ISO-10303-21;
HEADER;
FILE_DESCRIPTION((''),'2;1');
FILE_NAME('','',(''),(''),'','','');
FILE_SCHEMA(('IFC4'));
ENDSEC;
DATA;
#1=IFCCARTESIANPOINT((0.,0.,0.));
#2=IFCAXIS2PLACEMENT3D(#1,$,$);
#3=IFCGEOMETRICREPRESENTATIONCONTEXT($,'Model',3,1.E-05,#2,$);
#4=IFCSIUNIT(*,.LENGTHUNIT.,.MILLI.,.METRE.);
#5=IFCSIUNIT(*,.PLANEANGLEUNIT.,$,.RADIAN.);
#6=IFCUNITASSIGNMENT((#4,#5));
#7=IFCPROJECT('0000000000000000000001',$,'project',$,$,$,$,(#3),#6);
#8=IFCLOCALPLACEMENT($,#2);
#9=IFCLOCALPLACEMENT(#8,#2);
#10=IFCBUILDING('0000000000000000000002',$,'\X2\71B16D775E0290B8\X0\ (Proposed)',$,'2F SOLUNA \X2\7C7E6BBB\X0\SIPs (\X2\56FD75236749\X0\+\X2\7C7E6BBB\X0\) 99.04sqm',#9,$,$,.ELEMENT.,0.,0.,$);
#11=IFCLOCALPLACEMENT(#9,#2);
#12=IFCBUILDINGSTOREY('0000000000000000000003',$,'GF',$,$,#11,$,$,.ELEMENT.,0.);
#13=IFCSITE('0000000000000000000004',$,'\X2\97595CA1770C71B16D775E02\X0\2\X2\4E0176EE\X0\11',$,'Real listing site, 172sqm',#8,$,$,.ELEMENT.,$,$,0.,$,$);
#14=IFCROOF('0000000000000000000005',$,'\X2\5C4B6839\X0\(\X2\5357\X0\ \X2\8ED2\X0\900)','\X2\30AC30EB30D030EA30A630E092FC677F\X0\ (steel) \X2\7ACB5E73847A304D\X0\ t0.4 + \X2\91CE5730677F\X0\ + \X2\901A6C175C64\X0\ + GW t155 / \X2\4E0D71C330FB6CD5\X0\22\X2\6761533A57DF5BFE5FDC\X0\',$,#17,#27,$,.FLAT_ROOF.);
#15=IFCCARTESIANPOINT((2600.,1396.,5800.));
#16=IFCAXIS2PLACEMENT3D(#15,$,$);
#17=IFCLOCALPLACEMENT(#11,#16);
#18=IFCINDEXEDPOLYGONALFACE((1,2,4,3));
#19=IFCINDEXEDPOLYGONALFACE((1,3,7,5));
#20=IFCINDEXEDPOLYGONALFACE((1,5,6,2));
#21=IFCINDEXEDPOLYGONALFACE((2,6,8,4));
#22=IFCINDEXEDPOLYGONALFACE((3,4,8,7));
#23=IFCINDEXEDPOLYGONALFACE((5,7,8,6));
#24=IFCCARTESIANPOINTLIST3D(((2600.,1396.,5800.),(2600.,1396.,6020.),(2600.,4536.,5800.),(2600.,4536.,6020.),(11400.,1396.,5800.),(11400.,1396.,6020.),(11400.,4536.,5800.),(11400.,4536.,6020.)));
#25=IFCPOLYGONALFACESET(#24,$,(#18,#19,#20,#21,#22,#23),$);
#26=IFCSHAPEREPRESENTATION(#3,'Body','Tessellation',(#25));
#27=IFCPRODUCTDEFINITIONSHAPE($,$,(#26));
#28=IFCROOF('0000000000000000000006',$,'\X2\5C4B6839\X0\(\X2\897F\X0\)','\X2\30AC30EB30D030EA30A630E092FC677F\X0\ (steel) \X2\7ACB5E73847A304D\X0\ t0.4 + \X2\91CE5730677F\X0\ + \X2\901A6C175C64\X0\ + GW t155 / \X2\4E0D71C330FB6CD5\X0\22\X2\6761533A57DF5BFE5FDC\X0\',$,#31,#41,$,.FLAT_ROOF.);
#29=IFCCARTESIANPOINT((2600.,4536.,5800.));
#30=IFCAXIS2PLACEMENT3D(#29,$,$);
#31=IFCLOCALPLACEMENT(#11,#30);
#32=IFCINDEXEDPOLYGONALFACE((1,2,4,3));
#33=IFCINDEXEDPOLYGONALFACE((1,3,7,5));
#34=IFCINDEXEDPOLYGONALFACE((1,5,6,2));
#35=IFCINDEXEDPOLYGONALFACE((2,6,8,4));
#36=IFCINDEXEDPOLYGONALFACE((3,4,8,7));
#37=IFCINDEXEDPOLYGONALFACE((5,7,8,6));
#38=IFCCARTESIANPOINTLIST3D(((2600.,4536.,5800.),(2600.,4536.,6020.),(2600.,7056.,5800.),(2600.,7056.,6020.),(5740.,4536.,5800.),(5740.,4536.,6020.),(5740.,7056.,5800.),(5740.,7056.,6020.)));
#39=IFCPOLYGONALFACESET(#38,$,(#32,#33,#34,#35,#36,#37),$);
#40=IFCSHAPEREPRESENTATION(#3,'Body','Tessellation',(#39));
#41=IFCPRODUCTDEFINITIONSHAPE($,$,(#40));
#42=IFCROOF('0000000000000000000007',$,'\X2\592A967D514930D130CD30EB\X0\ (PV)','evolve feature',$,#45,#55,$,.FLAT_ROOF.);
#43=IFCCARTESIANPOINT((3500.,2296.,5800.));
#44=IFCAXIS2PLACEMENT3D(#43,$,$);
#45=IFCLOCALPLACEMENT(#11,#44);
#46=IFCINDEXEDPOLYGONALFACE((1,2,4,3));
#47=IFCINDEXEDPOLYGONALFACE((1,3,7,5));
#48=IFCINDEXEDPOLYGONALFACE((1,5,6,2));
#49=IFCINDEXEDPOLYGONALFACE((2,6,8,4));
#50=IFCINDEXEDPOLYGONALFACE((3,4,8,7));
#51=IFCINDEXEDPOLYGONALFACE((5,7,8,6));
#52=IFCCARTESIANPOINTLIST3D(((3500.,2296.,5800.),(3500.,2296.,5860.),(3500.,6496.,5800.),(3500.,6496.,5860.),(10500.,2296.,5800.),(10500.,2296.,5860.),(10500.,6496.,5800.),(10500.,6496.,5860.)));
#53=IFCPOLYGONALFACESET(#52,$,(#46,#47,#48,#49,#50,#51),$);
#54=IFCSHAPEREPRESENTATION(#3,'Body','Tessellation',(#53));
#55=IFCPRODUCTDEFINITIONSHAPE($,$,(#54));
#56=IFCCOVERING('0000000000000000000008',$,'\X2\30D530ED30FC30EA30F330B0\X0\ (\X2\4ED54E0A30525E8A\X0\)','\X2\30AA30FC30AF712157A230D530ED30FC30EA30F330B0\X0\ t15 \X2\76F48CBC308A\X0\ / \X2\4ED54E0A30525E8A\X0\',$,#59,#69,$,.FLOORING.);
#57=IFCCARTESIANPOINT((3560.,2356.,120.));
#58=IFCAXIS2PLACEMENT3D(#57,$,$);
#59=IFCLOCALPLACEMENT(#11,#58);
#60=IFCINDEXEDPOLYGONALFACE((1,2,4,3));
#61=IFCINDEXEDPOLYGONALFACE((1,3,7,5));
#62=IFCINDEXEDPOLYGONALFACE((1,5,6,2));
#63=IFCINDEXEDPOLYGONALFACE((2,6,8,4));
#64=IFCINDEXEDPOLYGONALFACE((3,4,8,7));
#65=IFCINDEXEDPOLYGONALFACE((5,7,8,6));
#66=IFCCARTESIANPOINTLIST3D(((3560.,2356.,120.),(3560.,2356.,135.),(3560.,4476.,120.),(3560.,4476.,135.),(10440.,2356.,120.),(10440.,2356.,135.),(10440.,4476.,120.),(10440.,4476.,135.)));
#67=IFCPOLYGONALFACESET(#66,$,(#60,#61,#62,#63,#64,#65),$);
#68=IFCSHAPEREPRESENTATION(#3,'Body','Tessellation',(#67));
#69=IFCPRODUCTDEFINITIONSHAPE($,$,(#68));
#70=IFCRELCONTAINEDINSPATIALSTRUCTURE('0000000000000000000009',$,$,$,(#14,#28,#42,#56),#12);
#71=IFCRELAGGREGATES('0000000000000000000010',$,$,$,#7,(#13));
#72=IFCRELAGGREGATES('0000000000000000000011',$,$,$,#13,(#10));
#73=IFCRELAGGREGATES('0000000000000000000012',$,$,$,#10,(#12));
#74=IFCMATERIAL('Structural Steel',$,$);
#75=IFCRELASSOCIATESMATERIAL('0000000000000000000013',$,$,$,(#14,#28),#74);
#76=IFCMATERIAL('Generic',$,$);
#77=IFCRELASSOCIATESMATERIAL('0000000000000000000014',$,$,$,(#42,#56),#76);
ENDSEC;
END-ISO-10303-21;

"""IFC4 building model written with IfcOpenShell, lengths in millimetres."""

from ifc_helpers import new_model, si_unit, frame, frame_2d, origin, place, context, project, spatial, rectangle, extrude, material, element, save


model = new_model("IFC4")

# Units and contexts
model_context = context("Model", 3, precision=1e-05, world=origin())
ifc_project = project(units=[si_unit("LENGTHUNIT", "METRE", prefix="MILLI"), si_unit("PLANEANGLEUNIT", "RADIAN")], contexts=[model_context])

# Site, building, storey
site_placement = place(None, origin())
site = spatial("IfcSite", under=ifc_project, at=site_placement, Name="静岡県熱海市2丁目11", ObjectType="Real listing site, 172sqm", CompositionType="ELEMENT", RefElevation=0.0)
building_placement = place(site_placement, origin())
building = spatial("IfcBuilding", under=site, at=building_placement, Name="熱海市邸 (Proposed)", ObjectType="2F SOLUNA 籾殻SIPs (国産杉+籾殻) 99.04sqm", CompositionType="ELEMENT", ElevationOfRefHeight=0.0, ElevationOfTerrain=0.0)
storey_placement = place(building_placement, origin())
storey = spatial("IfcBuildingStorey", under=building, at=storey_placement, Name="GF", CompositionType="ELEMENT", Elevation=0.0)

# Shared definitions
ifc_material_1 = material(Name="Generic")

# Roofs
ifc_material_2 = material(Name="Structural Steel")
roof_1_placement = place(storey_placement, frame((2600.0, 1396.0, 5800.0)))
element("IfcRoof", 1, at=roof_1_placement, inside=storey, material=ifc_material_2, Name="屋根(南 軒900)", Description="ガルバリウム鋼板 (steel) 立平葺き t0.4 + 野地板 + 通気層 + GW t155 / 不燃・法22条区域対応", PredefinedType="FLAT_ROOF", context=model_context, shape_type="SweptSolid", body=[
    extrude(rectangle(XDim=8800.0, YDim=3140.0, at=frame_2d((4400.0, 1570.0))), frame((2600.0, 1396.0, 5800.0)), (0.0, 0.0, 1.0), 220.0),
])
roof_2_placement = place(storey_placement, frame((2600.0, 4536.0, 5800.0)))
element("IfcRoof", 2, at=roof_2_placement, inside=storey, material=ifc_material_2, Name="屋根(西)", Description="ガルバリウム鋼板 (steel) 立平葺き t0.4 + 野地板 + 通気層 + GW t155 / 不燃・法22条区域対応", PredefinedType="FLAT_ROOF", context=model_context, shape_type="SweptSolid", body=[
    extrude(rectangle(XDim=3140.0, YDim=2520.0, at=frame_2d((1570.0, 1260.0))), frame((2600.0, 4536.0, 5800.0)), (0.0, 0.0, 1.0), 220.0),
])
roof_3_placement = place(storey_placement, frame((3500.0, 2296.0, 5800.0)))
element("IfcRoof", 3, at=roof_3_placement, inside=storey, material=ifc_material_1, Name="太陽光パネル (PV)", Description="evolve feature", PredefinedType="FLAT_ROOF", context=model_context, shape_type="SweptSolid", body=[
    extrude(rectangle(XDim=7000.0, YDim=4200.0, at=frame_2d((3500.0, 2100.0))), frame((3500.0, 2296.0, 5800.0)), (0.0, 0.0, 1.0), 60.0),
])

# Covering
covering_placement = place(storey_placement, frame((3560.0, 2356.0, 120.0)))
element("IfcCovering", 4, at=covering_placement, inside=storey, material=ifc_material_1, Name="フローリング (仕上げ床)", Description="オーク無垢フローリング t15 直貼り / 仕上げ床", PredefinedType="FLOORING", context=model_context, shape_type="SweptSolid", body=[
    extrude(rectangle(XDim=6880.0, YDim=2120.0, at=frame_2d((3440.0, 1060.0))), frame((3560.0, 2356.0, 120.0)), (0.0, 0.0, 1.0), 15.0),
])

save(model, "model.ifc")
